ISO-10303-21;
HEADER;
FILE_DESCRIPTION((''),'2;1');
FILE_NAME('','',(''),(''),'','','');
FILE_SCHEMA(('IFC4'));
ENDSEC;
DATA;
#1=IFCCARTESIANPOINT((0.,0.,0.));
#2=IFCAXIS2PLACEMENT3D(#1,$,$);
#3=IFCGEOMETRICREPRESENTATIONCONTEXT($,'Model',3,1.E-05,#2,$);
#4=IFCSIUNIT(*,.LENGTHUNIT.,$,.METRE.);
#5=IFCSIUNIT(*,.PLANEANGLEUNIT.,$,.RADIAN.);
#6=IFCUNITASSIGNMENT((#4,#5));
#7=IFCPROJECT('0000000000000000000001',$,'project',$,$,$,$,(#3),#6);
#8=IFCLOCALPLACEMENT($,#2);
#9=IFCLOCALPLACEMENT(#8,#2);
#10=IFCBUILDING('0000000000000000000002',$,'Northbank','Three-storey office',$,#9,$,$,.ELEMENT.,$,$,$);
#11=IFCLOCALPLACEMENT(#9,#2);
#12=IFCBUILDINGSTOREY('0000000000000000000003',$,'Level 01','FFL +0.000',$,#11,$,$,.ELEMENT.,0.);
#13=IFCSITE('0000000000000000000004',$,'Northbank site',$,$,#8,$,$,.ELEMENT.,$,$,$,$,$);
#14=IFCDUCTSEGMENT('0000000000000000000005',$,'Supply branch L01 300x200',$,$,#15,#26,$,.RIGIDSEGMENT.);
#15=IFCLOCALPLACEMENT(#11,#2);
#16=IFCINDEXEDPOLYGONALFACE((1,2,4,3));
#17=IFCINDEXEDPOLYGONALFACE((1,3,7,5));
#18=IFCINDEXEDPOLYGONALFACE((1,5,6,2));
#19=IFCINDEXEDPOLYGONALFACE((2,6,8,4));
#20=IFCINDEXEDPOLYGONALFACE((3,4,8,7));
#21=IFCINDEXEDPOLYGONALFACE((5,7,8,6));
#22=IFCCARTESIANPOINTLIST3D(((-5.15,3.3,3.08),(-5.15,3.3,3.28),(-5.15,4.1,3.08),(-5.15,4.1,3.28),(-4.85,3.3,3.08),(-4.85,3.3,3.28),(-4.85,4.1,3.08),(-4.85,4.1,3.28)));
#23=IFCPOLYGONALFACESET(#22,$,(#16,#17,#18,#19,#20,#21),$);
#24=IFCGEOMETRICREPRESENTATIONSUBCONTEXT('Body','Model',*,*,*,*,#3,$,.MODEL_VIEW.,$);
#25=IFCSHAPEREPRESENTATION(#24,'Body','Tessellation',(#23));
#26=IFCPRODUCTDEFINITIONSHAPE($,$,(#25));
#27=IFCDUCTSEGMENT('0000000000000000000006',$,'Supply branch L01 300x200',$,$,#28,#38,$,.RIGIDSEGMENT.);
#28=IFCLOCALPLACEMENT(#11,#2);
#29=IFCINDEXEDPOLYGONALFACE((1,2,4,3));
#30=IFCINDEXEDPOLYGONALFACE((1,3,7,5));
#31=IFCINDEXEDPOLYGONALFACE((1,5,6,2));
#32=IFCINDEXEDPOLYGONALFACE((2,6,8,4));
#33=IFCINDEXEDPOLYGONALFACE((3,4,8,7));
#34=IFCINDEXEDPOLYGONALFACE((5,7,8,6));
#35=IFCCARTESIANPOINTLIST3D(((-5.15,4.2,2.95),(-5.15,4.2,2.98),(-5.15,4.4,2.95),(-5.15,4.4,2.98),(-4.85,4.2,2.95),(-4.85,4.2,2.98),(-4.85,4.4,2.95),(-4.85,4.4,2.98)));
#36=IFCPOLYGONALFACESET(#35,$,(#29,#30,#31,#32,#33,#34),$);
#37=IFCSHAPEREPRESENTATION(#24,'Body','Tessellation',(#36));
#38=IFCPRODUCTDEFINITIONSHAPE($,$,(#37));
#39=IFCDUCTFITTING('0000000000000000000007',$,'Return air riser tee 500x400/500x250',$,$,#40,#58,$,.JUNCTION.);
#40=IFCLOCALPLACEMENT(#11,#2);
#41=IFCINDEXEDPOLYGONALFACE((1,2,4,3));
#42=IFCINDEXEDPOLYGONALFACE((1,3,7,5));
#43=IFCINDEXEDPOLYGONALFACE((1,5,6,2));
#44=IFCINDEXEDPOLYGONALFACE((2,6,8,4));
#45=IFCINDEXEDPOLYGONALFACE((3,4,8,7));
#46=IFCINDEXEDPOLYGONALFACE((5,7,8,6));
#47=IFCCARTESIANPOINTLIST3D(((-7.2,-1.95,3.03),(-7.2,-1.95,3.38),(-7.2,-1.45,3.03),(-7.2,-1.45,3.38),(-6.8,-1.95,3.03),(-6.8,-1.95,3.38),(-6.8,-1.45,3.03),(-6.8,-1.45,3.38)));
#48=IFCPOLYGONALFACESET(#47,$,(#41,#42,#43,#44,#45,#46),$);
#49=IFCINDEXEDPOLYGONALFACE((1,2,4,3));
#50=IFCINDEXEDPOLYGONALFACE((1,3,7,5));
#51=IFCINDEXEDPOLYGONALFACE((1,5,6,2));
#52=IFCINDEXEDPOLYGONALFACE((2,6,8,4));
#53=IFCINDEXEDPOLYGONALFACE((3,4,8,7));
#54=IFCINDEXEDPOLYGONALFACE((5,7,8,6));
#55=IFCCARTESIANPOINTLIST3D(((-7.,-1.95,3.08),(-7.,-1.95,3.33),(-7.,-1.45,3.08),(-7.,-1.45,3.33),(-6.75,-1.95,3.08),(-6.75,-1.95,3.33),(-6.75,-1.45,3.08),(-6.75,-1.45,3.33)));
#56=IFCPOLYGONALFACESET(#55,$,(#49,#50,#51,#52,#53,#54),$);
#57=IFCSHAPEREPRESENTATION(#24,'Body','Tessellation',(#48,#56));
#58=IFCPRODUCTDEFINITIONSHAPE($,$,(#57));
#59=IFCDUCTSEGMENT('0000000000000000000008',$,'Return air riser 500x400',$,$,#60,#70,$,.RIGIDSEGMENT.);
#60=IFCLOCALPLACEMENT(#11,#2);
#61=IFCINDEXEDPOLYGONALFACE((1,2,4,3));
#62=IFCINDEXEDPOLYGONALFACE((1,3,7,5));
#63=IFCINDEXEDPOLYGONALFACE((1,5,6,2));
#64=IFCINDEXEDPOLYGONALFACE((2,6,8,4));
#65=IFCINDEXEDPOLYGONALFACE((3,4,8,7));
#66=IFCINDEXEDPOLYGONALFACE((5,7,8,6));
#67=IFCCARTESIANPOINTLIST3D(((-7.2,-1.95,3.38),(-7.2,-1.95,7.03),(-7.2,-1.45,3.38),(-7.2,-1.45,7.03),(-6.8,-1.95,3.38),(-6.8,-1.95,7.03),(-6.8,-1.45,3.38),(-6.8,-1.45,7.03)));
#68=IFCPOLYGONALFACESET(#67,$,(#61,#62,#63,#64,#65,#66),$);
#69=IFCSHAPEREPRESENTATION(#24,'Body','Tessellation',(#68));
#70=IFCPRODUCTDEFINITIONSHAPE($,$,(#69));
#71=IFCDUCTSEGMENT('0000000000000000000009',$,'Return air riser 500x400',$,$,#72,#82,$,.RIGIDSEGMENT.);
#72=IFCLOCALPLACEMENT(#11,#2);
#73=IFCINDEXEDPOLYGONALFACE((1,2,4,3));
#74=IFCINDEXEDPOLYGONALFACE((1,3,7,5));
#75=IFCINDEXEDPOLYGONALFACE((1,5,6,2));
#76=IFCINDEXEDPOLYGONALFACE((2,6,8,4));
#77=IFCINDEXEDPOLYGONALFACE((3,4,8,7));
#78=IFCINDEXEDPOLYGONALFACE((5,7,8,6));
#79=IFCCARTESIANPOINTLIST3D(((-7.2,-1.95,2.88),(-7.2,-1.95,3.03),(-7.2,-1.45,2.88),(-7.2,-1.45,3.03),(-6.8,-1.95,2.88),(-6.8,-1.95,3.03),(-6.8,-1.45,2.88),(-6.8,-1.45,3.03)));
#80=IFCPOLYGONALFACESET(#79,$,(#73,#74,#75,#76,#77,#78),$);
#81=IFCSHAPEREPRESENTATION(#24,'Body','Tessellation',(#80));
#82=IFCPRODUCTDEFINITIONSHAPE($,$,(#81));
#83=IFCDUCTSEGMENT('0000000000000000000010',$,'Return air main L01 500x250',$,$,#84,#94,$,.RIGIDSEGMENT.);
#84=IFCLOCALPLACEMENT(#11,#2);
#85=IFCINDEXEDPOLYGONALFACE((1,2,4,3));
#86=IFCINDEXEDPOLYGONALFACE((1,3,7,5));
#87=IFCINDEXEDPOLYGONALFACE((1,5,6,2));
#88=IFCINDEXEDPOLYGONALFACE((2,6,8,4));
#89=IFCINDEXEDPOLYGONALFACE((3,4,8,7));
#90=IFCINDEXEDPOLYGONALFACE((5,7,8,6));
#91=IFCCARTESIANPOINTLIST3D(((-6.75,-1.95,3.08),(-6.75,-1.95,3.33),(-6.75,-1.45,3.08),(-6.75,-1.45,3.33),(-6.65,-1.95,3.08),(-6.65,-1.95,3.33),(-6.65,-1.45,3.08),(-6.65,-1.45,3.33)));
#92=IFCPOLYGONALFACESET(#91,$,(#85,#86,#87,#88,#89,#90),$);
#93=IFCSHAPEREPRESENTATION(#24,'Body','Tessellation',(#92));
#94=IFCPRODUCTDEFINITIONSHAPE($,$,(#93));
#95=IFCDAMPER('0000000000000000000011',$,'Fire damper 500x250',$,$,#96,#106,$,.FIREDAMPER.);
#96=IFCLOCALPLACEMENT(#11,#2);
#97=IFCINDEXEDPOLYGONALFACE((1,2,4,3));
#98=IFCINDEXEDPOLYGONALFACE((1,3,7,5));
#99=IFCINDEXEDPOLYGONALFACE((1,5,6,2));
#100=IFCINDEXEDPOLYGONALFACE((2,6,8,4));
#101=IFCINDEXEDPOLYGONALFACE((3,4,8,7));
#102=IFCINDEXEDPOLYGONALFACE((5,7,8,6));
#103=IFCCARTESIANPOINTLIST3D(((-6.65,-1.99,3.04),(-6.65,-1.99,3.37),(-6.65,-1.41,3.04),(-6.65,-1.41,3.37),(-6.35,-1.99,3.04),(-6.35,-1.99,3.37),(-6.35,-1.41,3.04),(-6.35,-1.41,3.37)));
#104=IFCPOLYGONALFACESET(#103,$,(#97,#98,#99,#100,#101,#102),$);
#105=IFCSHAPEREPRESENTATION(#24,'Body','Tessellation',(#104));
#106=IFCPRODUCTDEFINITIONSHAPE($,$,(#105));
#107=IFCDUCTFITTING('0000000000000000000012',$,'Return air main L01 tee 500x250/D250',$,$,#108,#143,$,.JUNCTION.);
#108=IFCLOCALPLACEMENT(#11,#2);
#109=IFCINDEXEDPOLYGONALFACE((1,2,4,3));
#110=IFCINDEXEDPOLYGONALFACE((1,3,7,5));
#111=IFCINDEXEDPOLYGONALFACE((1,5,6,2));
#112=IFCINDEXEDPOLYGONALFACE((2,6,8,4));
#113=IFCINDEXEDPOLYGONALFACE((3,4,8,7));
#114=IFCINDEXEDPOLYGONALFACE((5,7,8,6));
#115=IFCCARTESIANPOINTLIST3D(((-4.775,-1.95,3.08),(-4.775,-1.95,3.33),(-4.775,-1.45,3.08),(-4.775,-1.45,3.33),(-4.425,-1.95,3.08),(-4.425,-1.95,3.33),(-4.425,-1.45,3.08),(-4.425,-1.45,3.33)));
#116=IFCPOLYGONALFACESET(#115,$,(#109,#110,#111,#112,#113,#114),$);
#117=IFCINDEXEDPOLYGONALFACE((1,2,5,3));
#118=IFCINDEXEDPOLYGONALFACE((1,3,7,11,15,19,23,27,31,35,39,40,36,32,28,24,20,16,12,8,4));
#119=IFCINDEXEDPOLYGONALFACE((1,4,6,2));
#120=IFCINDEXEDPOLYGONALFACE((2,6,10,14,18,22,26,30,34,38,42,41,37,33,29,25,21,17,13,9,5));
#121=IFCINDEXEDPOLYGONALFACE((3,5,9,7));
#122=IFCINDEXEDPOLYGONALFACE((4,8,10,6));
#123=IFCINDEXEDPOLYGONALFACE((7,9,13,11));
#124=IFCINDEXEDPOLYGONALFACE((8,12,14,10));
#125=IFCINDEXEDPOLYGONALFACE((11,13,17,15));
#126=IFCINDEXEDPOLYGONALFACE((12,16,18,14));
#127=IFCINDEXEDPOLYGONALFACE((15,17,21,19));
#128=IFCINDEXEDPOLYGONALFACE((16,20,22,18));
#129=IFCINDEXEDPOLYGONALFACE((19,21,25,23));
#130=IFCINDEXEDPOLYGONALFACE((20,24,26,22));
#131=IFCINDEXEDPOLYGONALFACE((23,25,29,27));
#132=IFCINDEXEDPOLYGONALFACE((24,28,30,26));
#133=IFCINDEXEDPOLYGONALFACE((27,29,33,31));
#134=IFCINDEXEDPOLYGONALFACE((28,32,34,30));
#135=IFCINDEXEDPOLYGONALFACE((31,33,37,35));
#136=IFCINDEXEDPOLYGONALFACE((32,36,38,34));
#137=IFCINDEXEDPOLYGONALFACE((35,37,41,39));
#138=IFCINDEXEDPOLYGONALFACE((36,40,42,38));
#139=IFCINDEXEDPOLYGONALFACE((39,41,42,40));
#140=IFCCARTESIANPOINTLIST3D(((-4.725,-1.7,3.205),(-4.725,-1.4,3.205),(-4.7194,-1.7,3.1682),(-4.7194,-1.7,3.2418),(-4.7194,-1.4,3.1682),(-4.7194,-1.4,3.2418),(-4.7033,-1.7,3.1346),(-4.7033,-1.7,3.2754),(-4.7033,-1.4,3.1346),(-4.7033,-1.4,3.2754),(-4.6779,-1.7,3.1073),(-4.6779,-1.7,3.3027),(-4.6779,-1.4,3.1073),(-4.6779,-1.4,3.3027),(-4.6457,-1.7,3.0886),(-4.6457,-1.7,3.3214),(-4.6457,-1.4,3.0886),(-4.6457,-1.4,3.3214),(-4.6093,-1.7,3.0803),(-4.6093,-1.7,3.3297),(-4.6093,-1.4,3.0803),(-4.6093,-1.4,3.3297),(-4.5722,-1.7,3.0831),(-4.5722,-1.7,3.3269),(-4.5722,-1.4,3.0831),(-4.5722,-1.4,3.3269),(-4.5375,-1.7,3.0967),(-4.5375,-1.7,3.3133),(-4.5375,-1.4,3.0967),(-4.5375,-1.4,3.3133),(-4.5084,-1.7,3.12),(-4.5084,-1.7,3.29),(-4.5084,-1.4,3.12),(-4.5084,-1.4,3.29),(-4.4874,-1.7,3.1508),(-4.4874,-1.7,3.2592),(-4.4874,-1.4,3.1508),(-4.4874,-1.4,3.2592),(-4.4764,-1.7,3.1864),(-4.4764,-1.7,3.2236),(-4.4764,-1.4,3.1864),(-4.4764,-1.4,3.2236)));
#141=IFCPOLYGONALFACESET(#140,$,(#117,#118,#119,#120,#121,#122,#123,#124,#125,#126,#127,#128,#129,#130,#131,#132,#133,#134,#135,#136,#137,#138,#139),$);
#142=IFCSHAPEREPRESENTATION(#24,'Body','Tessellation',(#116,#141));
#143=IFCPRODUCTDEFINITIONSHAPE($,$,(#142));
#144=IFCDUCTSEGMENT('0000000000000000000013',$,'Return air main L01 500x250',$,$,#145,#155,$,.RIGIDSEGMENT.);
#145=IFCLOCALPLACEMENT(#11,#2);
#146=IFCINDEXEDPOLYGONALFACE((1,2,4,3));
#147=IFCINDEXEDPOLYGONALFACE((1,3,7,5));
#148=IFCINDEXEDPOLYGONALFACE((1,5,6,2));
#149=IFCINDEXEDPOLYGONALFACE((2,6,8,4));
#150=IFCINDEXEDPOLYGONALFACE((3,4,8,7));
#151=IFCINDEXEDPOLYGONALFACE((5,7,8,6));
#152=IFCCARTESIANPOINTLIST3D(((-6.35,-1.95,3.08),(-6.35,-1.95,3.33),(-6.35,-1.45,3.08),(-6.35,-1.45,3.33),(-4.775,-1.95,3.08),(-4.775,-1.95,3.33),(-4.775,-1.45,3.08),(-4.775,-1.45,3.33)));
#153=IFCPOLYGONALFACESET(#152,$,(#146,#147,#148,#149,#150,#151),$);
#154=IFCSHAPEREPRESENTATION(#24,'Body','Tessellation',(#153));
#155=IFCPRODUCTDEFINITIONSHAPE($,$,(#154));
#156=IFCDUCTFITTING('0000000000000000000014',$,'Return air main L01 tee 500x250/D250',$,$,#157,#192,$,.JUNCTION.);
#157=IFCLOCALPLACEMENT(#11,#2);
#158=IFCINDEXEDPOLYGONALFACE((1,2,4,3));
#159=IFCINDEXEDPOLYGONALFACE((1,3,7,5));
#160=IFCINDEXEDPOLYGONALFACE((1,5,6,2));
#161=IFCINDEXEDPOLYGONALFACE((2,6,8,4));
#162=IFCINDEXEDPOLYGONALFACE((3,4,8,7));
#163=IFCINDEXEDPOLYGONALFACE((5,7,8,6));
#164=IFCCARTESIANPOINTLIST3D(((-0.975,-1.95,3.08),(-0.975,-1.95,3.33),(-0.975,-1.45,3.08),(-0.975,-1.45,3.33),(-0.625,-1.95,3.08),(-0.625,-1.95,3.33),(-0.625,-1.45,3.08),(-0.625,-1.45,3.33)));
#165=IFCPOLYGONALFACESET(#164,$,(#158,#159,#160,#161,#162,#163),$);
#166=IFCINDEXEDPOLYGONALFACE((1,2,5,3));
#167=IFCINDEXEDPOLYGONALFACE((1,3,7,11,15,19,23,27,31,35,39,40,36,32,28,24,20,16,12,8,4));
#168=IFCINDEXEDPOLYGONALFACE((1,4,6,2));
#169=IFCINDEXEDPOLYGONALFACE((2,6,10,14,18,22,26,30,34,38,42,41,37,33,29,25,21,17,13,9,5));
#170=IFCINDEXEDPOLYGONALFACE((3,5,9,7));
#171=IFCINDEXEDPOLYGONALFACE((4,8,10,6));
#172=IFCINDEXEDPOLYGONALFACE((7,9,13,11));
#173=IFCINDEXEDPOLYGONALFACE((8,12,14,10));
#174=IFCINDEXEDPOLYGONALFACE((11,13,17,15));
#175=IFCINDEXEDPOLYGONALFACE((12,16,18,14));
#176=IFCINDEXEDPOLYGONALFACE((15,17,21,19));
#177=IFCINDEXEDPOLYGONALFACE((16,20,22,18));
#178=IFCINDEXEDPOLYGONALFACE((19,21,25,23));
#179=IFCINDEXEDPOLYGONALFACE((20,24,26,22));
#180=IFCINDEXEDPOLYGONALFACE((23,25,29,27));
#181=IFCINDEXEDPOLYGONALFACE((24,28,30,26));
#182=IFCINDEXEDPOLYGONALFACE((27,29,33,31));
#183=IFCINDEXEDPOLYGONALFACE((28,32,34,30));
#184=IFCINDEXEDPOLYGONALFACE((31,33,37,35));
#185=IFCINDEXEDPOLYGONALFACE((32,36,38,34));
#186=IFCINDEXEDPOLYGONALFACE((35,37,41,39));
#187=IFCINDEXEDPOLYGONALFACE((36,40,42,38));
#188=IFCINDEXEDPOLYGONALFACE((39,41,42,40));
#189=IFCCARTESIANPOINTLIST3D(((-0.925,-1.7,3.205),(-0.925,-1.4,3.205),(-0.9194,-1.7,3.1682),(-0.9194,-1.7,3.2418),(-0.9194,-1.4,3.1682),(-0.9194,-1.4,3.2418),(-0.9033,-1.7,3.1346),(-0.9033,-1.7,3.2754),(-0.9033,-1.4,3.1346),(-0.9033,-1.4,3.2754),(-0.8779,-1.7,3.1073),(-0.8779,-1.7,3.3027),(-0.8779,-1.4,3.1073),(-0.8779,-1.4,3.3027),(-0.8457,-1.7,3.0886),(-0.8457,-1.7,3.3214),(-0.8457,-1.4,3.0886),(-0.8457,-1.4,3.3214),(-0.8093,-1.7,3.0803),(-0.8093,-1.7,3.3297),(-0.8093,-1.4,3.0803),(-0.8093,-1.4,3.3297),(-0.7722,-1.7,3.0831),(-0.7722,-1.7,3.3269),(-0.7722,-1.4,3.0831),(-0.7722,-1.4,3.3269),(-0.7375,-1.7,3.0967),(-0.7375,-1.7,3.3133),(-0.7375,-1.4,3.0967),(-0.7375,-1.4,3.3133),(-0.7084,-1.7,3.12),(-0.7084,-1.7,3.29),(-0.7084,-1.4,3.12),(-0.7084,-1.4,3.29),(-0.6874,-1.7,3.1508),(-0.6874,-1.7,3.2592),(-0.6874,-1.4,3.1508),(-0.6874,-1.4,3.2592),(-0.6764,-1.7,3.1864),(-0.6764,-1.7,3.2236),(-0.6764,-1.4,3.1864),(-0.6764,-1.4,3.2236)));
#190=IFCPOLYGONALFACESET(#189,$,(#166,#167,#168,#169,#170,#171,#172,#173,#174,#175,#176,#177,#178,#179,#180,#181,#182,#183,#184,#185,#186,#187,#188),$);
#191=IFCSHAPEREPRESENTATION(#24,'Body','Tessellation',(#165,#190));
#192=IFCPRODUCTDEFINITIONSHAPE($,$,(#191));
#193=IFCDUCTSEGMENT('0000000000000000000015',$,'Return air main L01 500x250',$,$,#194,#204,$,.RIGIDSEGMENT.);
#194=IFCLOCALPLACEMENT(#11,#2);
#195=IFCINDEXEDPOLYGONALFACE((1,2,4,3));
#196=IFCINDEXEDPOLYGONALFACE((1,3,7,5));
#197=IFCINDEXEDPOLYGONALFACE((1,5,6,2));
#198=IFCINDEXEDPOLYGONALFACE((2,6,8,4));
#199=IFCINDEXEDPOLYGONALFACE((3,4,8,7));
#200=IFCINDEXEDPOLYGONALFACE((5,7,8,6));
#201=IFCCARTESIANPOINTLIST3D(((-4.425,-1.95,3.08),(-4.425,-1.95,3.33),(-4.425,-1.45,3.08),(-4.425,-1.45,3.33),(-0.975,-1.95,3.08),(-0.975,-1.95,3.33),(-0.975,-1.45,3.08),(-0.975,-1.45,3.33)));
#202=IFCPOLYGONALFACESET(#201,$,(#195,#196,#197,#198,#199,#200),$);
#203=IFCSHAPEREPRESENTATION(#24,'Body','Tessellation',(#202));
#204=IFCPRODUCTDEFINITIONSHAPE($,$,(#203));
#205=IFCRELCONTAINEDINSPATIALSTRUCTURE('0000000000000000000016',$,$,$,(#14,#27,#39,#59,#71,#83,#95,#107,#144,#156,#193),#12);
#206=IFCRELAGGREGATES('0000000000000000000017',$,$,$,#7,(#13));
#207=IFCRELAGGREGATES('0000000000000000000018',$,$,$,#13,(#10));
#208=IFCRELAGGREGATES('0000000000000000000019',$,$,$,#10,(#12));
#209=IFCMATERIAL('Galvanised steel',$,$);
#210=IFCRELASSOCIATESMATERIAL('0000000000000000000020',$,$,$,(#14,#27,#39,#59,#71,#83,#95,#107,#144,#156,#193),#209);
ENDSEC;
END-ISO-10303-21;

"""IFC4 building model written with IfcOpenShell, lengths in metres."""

from ifc_helpers import new_model, si_unit, frame, origin, place, context, subcontext, project, spatial, rectangle, circle, extrude, material, element, save


model = new_model("IFC4")

# Units and contexts
model_context = context("Model", 3, precision=1e-05, world=origin())
body_context = subcontext(model_context, "Body", "Model", "MODEL_VIEW")
ifc_project = project(units=[si_unit("LENGTHUNIT", "METRE"), si_unit("PLANEANGLEUNIT", "RADIAN")], contexts=[model_context])

# Site, building, storey
site_placement = place(None, origin())
site = spatial("IfcSite", under=ifc_project, at=site_placement, Name="Northbank site", CompositionType="ELEMENT")
building_placement = place(site_placement, origin())
building = spatial("IfcBuilding", under=site, at=building_placement, Name="Northbank", Description="Three-storey office", CompositionType="ELEMENT")
storey_placement = place(building_placement, origin())
storey = spatial("IfcBuildingStorey", under=building, at=storey_placement, Name="Level 01", Description="FFL +0.000", CompositionType="ELEMENT", Elevation=0.0)

# Shared definitions
ifc_material_1 = material(Name="Galvanised steel")

# Duct segments
duct_segment_1_placement = place(storey_placement, origin())
element("IfcDuctSegment", 1, at=duct_segment_1_placement, inside=storey, material=ifc_material_1, Name="Supply branch L01 300x200", PredefinedType="RIGIDSEGMENT", context=body_context, shape_type="SweptSolid", body=[
    extrude(rectangle(XDim=0.3, YDim=0.2), frame((-5.0, 3.3, 3.18), z_axis=(0.0, 1.0, 0.0), x_axis=(-1.0, 0.0, 0.0)), (0.0, 0.0, 1.0), 0.8),
])
duct_segment_2_placement = place(storey_placement, origin())
element("IfcDuctSegment", 2, at=duct_segment_2_placement, inside=storey, material=ifc_material_1, Name="Supply branch L01 300x200", PredefinedType="RIGIDSEGMENT", context=body_context, shape_type="SweptSolid", body=[
    extrude(rectangle(XDim=0.3, YDim=0.2), frame((-5.0, 4.3, 2.98), z_axis=(0.0, 0.0, -1.0), x_axis=(-1.0, 0.0, 0.0)), (0.0, 0.0, 1.0), 0.03),
])

# Duct fitting
duct_fitting_1_placement = place(storey_placement, origin())
element("IfcDuctFitting", 3, at=duct_fitting_1_placement, inside=storey, material=ifc_material_1, Name="Return air riser tee 500x400/500x250", PredefinedType="JUNCTION", context=body_context, shape_type="SweptSolid", body=[
    extrude(rectangle(XDim=0.5, YDim=0.4), frame((-7.0, -1.7, 3.38), z_axis=(0.0, 0.0, -1.0), x_axis=(0.0, -1.0, 0.0)), (0.0, 0.0, 1.0), 0.35),
    extrude(rectangle(XDim=0.5, YDim=0.25), frame((-7.0, -1.7, 3.205), z_axis=(1.0, 0.0, 0.0), x_axis=(0.0, 1.0, 0.0)), (0.0, 0.0, 1.0), 0.25),
])

# Duct segments
duct_segment_3_placement = place(storey_placement, origin())
element("IfcDuctSegment", 4, at=duct_segment_3_placement, inside=storey, material=ifc_material_1, Name="Return air riser 500x400", PredefinedType="RIGIDSEGMENT", context=body_context, shape_type="SweptSolid", body=[
    extrude(rectangle(XDim=0.5, YDim=0.4), frame((-7.0, -1.7, 7.03), z_axis=(0.0, 0.0, -1.0), x_axis=(0.0, -1.0, 0.0)), (0.0, 0.0, 1.0), 3.65),
])
duct_segment_4_placement = place(storey_placement, origin())
element("IfcDuctSegment", 5, at=duct_segment_4_placement, inside=storey, material=ifc_material_1, Name="Return air riser 500x400", PredefinedType="RIGIDSEGMENT", context=body_context, shape_type="SweptSolid", body=[
    extrude(rectangle(XDim=0.5, YDim=0.4), frame((-7.0, -1.7, 3.03), z_axis=(0.0, 0.0, -1.0), x_axis=(0.0, -1.0, 0.0)), (0.0, 0.0, 1.0), 0.15),
])
duct_segment_5_placement = place(storey_placement, origin())
element("IfcDuctSegment", 6, at=duct_segment_5_placement, inside=storey, material=ifc_material_1, Name="Return air main L01 500x250", PredefinedType="RIGIDSEGMENT", context=body_context, shape_type="SweptSolid", body=[
    extrude(rectangle(XDim=0.5, YDim=0.25), frame((-6.75, -1.7, 3.205), z_axis=(1.0, 0.0, 0.0), x_axis=(0.0, 1.0, 0.0)), (0.0, 0.0, 1.0), 0.1),
])

# Damper
damper_1_placement = place(storey_placement, origin())
element("IfcDamper", 7, at=damper_1_placement, inside=storey, material=ifc_material_1, Name="Fire damper 500x250", PredefinedType="FIREDAMPER", context=body_context, shape_type="SweptSolid", body=[
    extrude(rectangle(XDim=0.58, YDim=0.33), frame((-6.65, -1.7, 3.205), z_axis=(1.0, 0.0, 0.0), x_axis=(0.0, 1.0, 0.0)), (0.0, 0.0, 1.0), 0.3),
])

# Duct fitting
duct_fitting_2_placement = place(storey_placement, origin())
element("IfcDuctFitting", 8, at=duct_fitting_2_placement, inside=storey, material=ifc_material_1, Name="Return air main L01 tee 500x250/D250", PredefinedType="JUNCTION", context=body_context, shape_type="SweptSolid", body=[
    extrude(rectangle(XDim=0.5, YDim=0.25), frame((-4.775, -1.7, 3.205), z_axis=(1.0, 0.0, 0.0), x_axis=(0.0, 1.0, 0.0)), (0.0, 0.0, 1.0), 0.35),
    extrude(circle(Radius=0.125), frame((-4.6, -1.7, 3.205), z_axis=(0.0, 1.0, 0.0), x_axis=(-1.0, 0.0, 0.0)), (0.0, 0.0, 1.0), 0.3),
])

# Duct segment
duct_segment_6_placement = place(storey_placement, origin())
element("IfcDuctSegment", 9, at=duct_segment_6_placement, inside=storey, material=ifc_material_1, Name="Return air main L01 500x250", PredefinedType="RIGIDSEGMENT", context=body_context, shape_type="SweptSolid", body=[
    extrude(rectangle(XDim=0.5, YDim=0.25), frame((-6.35, -1.7, 3.205), z_axis=(1.0, 0.0, 0.0), x_axis=(0.0, 1.0, 0.0)), (0.0, 0.0, 1.0), 1.575),
])

# Duct fitting
duct_fitting_3_placement = place(storey_placement, origin())
element("IfcDuctFitting", 10, at=duct_fitting_3_placement, inside=storey, material=ifc_material_1, Name="Return air main L01 tee 500x250/D250", PredefinedType="JUNCTION", context=body_context, shape_type="SweptSolid", body=[
    extrude(rectangle(XDim=0.5, YDim=0.25), frame((-0.975, -1.7, 3.205), z_axis=(1.0, 0.0, 0.0), x_axis=(0.0, 1.0, 0.0)), (0.0, 0.0, 1.0), 0.35),
    extrude(circle(Radius=0.125), frame((-0.8, -1.7, 3.205), z_axis=(0.0, 1.0, 0.0), x_axis=(-1.0, 0.0, 0.0)), (0.0, 0.0, 1.0), 0.3),
])

# Duct segment
duct_segment_7_placement = place(storey_placement, origin())
element("IfcDuctSegment", 11, at=duct_segment_7_placement, inside=storey, material=ifc_material_1, Name="Return air main L01 500x250", PredefinedType="RIGIDSEGMENT", context=body_context, shape_type="SweptSolid", body=[
    extrude(rectangle(XDim=0.5, YDim=0.25), frame((-4.425, -1.7, 3.205), z_axis=(1.0, 0.0, 0.0), x_axis=(0.0, 1.0, 0.0)), (0.0, 0.0, 1.0), 3.45),
])

save(model, "model.ifc")
